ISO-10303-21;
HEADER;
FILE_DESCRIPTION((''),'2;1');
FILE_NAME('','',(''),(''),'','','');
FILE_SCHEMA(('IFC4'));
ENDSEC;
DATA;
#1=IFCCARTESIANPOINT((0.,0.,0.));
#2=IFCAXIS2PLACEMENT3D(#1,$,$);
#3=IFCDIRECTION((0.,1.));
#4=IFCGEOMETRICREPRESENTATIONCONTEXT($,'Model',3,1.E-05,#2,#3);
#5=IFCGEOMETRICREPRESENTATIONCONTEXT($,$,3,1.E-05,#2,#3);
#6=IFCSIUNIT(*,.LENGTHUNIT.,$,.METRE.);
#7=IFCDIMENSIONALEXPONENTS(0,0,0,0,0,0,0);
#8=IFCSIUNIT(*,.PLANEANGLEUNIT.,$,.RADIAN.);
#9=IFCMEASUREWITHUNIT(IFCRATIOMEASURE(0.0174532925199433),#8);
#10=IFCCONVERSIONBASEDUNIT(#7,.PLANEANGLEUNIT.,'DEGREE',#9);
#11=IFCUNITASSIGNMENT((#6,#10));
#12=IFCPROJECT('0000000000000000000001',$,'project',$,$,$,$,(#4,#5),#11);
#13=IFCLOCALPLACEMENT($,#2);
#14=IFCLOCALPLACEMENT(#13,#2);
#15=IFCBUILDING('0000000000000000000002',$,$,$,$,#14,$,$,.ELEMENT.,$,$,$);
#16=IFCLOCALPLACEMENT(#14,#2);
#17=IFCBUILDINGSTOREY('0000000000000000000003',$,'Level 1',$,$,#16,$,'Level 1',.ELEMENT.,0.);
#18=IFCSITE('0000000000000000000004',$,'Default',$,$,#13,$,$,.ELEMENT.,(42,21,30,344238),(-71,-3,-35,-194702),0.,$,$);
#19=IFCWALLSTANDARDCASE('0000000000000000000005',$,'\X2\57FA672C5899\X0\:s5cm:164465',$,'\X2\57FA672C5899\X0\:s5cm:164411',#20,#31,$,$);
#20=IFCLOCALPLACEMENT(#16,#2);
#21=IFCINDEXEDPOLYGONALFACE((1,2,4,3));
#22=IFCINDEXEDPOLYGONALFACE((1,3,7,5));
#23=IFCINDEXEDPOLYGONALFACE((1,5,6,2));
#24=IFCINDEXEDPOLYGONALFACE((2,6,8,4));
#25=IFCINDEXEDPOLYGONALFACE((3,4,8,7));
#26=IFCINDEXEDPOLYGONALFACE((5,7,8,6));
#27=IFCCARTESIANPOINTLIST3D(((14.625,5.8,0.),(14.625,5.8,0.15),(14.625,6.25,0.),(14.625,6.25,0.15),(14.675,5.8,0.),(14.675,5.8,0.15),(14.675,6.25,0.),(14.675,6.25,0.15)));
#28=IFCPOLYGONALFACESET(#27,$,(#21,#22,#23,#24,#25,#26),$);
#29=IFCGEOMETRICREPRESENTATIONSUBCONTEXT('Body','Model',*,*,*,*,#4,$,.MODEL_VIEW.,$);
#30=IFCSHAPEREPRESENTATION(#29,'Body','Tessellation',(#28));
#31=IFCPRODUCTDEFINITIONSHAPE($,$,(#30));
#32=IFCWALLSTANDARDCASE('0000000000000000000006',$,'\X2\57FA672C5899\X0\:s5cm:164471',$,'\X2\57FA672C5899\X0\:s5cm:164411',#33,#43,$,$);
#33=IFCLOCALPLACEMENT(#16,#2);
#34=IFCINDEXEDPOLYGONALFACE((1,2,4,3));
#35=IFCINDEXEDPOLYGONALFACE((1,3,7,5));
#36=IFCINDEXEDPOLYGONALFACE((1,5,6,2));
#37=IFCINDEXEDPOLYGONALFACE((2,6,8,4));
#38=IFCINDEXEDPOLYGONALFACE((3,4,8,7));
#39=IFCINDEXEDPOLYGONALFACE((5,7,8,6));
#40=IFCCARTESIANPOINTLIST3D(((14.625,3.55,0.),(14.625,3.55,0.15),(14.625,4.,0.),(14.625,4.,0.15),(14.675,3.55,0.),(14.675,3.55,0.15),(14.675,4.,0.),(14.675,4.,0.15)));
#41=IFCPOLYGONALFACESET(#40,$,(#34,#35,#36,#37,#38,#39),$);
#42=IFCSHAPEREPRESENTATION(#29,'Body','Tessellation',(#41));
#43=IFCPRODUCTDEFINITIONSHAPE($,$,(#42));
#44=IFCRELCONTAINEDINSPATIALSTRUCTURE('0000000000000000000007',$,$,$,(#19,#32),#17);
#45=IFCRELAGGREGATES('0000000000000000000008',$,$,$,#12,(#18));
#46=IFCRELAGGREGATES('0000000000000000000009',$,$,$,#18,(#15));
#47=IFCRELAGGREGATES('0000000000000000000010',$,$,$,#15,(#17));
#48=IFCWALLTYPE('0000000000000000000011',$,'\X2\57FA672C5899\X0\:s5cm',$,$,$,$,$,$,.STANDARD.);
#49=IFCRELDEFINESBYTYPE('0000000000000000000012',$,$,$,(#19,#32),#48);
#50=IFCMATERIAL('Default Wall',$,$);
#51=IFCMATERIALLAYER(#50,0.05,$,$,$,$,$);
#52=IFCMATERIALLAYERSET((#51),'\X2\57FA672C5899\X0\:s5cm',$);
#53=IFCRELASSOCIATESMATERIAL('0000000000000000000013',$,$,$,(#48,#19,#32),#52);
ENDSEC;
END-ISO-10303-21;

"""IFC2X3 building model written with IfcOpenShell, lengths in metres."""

from ifc_helpers import new_model, entity, si_unit, converted_unit, direction, frame, frame_2d, origin, place, context, subcontext, project, spatial, rectangle, extrude, material, layer, layer_set, layer_usage, type_object, element, save


model = new_model("IFC2X3")

# Units and contexts
model_context = context("Model", 3, precision=1e-05, world=origin(), true_north=direction((0.0, 1.0)))
context_of_model = context(None, 3, precision=1e-05, world=origin(), true_north=direction((0.0, 1.0)))
body_context = subcontext(model_context, "Body", "Model", "MODEL_VIEW")
ifc_project = project(units=[si_unit("LENGTHUNIT", "METRE"), converted_unit("PLANEANGLEUNIT", "DEGREE", entity("IfcRatioMeasure", 0.0174532925199433), si_unit("PLANEANGLEUNIT", "RADIAN"), dimensions=[0, 0, 0, 0, 0, 0, 0])], contexts=[model_context, context_of_model])

# Site, building, storey
site_placement = place(None, origin())
site = spatial("IfcSite", under=ifc_project, at=site_placement, Name="Default", CompositionType="ELEMENT", RefLatitude=(42, 21, 30, 344238), RefLongitude=(-71, -3, -35, -194702), RefElevation=0.0)
building_placement = place(site_placement, origin())
building = spatial("IfcBuilding", under=site, at=building_placement, CompositionType="ELEMENT")
storey_placement = place(building_placement, origin())
storey = spatial("IfcBuildingStorey", under=building, at=storey_placement, Name="Level 1", LongName="Level 1", CompositionType="ELEMENT", Elevation=0.0)

# Shared definitions
ifc_material_1 = material(Name="Default Wall")

# Walls
ifc_layer_1 = layer(ifc_material_1, 0.05)
ifc_layer_set_1 = layer_set([ifc_layer_1], Name="基本墙:s5cm")
wall_type_1 = type_object("IfcWallType", Name="基本墙:s5cm", PredefinedType="STANDARD", material=ifc_layer_set_1)
ifc_layer_usage_1 = layer_usage(ifc_layer_set_1, "AXIS2", "NEGATIVE", 0.025)
wall_1_placement = place(storey_placement, frame((14.65, 5.8, 0.0), z_axis=(0.0, 0.0, 1.0), x_axis=(0.0, 1.0, 0.0)))
element("IfcWallStandardCase", 1, at=wall_1_placement, inside=storey, type_object=wall_type_1, material=ifc_layer_usage_1, Name="基本墙:s5cm:164465", ObjectType="基本墙:s5cm:164411", context=body_context, shape_type="SweptSolid", body=[
    extrude(rectangle(XDim=0.45, YDim=0.05, at=frame_2d((0.225, 0.0), x_axis=(-1.0, 0.0))), origin(), (0.0, 0.0, 1.0), 0.15),
])
ifc_layer_usage_2 = layer_usage(ifc_layer_set_1, "AXIS2", "NEGATIVE", 0.025)
wall_2_placement = place(storey_placement, frame((14.65, 3.55, 0.0), z_axis=(0.0, 0.0, 1.0), x_axis=(0.0, 1.0, 0.0)))
element("IfcWallStandardCase", 2, at=wall_2_placement, inside=storey, type_object=wall_type_1, material=ifc_layer_usage_2, Name="基本墙:s5cm:164471", ObjectType="基本墙:s5cm:164411", context=body_context, shape_type="SweptSolid", body=[
    extrude(rectangle(XDim=0.45, YDim=0.05, at=frame_2d((0.225, 0.0), x_axis=(-1.0, 0.0))), origin(), (0.0, 0.0, 1.0), 0.15),
])

save(model, "model.ifc")
